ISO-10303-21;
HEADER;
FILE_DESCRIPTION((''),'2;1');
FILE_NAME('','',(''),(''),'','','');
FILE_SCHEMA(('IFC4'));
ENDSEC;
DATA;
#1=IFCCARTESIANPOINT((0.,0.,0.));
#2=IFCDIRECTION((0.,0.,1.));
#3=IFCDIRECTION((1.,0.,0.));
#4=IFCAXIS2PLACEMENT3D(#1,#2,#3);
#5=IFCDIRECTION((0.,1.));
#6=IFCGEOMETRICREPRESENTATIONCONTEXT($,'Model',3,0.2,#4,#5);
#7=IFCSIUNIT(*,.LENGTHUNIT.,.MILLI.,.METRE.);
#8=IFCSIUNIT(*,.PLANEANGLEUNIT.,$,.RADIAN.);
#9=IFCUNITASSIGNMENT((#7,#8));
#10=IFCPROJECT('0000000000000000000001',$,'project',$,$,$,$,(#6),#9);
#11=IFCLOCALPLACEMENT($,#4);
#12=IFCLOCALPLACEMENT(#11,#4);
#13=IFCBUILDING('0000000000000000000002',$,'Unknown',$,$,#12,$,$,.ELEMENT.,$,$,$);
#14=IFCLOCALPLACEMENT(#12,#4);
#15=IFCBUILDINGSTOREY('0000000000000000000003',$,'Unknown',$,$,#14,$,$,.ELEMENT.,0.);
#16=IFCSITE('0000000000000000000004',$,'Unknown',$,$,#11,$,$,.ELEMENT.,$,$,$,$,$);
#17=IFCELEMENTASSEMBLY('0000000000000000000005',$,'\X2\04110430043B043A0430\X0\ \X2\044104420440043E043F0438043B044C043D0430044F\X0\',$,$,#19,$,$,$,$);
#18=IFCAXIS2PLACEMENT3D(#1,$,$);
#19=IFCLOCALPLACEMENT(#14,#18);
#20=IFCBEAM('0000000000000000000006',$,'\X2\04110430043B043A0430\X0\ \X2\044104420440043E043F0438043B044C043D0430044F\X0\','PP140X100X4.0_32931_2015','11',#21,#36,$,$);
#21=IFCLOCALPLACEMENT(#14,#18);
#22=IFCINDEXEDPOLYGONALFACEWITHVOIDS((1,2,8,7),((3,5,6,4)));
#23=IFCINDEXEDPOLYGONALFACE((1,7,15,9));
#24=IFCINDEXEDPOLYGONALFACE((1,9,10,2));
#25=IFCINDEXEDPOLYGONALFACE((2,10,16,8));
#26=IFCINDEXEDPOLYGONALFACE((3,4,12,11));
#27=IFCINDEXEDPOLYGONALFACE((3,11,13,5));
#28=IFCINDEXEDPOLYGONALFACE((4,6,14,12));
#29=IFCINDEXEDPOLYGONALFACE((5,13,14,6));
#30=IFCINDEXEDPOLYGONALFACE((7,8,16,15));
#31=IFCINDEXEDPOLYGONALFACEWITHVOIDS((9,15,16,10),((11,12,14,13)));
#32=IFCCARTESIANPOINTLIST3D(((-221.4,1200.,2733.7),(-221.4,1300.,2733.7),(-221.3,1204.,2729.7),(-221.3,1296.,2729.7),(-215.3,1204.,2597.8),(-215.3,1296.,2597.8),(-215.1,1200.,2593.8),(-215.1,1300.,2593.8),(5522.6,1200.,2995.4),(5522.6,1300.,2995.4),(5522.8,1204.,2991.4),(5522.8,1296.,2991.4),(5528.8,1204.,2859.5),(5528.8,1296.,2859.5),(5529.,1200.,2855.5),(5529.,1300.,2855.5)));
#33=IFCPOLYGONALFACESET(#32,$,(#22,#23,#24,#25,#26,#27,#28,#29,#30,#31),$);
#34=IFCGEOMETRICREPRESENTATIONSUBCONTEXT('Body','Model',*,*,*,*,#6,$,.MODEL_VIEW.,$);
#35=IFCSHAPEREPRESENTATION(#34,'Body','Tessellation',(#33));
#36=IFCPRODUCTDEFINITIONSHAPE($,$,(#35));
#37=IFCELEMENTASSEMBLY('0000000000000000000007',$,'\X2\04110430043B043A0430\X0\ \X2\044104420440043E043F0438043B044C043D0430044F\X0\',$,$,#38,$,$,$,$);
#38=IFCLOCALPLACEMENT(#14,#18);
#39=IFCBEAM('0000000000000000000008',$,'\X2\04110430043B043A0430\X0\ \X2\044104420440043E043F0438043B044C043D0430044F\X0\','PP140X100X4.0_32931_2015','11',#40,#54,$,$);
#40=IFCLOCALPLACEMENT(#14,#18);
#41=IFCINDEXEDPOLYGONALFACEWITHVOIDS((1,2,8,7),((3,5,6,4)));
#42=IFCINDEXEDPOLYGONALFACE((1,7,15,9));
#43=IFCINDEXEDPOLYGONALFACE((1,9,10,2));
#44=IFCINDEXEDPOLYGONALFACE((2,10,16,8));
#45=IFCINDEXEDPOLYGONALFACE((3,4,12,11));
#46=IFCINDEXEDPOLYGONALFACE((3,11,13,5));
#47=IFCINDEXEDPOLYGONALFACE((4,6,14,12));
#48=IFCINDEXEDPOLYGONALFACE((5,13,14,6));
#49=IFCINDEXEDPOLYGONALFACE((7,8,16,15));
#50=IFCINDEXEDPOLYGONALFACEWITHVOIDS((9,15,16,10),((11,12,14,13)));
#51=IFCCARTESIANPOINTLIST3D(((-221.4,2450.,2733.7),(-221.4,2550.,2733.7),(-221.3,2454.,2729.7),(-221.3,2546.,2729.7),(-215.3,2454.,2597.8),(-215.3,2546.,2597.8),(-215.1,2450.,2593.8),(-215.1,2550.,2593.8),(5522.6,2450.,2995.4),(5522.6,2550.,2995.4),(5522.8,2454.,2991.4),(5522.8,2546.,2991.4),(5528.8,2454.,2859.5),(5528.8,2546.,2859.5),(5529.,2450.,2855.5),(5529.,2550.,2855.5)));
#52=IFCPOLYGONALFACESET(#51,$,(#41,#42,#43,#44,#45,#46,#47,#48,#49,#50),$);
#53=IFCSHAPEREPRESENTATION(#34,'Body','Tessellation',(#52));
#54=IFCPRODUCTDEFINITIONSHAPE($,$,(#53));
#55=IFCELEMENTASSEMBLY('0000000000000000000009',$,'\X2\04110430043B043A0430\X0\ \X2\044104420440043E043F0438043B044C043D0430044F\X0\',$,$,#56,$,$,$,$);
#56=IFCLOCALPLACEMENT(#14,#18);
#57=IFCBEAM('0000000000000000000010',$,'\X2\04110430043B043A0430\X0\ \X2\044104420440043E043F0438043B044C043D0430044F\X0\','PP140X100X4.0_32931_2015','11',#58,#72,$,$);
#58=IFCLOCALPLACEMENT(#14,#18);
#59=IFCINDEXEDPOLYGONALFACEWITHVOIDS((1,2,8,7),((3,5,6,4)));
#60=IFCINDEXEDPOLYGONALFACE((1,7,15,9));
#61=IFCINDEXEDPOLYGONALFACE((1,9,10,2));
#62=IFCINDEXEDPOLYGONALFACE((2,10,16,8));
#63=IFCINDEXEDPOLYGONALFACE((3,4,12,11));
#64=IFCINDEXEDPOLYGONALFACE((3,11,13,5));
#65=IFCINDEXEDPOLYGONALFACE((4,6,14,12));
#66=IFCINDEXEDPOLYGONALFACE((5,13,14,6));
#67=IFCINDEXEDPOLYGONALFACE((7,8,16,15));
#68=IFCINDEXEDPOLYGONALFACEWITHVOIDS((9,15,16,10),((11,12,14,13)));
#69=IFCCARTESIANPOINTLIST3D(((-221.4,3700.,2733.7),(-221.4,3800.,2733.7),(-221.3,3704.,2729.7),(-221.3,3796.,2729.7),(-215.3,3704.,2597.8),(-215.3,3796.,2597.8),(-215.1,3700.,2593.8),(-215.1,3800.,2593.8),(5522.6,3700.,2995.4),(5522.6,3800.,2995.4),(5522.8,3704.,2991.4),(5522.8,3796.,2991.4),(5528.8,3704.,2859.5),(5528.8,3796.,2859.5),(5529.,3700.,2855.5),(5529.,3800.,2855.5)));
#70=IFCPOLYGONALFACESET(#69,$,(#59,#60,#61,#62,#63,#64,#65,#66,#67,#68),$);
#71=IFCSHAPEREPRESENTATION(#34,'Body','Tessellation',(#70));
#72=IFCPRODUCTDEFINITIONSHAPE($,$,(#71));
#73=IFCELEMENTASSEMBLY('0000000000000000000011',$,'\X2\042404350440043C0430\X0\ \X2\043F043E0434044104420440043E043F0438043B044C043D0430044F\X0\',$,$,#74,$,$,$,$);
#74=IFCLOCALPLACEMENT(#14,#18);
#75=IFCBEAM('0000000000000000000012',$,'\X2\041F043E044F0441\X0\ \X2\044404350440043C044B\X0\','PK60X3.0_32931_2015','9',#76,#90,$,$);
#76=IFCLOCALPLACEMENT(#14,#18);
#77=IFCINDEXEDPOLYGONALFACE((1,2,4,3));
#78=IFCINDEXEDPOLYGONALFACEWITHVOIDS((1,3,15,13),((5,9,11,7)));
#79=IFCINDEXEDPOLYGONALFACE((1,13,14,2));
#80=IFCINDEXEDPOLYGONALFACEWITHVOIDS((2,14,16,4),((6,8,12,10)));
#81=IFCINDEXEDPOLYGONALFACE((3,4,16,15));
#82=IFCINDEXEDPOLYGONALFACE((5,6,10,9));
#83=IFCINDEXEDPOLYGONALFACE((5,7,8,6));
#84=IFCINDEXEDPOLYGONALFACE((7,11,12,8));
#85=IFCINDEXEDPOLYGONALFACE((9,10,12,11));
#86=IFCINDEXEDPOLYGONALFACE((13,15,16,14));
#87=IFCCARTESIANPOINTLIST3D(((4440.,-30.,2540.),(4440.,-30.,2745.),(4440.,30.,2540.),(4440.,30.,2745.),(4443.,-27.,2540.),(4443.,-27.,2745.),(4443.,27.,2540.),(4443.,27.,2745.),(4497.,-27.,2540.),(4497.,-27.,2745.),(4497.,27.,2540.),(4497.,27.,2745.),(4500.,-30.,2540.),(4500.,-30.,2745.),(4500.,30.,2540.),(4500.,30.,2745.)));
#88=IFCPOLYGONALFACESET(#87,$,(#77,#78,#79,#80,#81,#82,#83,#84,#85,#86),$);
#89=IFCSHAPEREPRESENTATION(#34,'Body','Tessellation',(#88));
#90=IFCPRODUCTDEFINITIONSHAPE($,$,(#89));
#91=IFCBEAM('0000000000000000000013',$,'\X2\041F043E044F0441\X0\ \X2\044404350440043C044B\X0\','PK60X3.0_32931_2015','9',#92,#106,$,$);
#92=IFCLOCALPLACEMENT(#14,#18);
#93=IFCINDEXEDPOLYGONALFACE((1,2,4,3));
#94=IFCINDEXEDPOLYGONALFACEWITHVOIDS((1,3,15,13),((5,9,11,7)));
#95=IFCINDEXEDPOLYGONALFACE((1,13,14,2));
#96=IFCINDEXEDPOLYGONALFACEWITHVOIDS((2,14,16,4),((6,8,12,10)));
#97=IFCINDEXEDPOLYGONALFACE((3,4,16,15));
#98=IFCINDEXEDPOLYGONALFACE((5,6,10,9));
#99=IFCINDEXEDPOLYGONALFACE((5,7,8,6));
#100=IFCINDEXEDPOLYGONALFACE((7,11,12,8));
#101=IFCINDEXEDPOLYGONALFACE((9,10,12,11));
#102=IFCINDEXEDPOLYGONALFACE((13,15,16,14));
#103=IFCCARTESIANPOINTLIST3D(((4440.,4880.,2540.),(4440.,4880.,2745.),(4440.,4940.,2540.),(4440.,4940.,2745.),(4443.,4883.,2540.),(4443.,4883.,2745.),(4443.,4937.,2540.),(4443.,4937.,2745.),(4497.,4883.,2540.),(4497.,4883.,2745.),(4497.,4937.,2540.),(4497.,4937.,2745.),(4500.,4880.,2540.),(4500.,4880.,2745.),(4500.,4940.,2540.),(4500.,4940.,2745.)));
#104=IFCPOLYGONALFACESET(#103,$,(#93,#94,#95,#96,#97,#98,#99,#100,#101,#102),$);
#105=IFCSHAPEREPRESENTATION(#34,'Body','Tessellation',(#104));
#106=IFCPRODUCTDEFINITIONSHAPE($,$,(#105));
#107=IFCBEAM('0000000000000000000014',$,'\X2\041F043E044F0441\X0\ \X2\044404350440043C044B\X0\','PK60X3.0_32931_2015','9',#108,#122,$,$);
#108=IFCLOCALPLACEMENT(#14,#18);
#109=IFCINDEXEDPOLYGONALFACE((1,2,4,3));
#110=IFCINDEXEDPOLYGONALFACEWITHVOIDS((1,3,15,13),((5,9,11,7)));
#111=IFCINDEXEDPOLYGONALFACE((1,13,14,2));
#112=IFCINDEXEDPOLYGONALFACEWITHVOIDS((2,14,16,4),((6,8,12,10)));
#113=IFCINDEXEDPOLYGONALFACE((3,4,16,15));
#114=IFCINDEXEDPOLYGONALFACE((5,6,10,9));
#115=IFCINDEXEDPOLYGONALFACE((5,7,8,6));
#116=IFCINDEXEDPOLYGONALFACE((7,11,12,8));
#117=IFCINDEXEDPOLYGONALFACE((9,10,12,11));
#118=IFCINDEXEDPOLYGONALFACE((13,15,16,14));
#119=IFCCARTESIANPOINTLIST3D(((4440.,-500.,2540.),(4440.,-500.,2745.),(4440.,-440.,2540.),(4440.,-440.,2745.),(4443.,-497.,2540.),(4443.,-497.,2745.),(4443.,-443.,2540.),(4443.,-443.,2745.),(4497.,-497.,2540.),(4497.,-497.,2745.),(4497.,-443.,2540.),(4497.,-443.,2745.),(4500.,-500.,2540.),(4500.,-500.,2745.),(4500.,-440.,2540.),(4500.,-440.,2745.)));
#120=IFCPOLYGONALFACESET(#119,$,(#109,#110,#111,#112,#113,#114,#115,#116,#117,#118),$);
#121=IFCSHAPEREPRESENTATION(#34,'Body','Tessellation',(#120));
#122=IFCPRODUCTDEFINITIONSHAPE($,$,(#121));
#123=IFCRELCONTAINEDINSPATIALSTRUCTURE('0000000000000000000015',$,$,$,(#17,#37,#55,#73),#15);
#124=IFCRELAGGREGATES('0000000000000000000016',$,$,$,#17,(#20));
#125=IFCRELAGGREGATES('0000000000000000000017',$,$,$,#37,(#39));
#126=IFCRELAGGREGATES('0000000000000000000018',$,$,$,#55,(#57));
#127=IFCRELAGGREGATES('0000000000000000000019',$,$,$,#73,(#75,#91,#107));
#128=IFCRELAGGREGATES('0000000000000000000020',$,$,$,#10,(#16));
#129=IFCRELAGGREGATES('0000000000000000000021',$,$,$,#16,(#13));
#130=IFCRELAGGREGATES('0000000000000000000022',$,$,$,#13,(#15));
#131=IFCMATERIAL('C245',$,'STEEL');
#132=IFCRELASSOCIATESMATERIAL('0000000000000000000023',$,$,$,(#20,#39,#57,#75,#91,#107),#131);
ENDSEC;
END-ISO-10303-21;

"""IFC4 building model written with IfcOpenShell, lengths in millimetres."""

from ifc_helpers import new_model, si_unit, direction, frame, origin_with_axes, place, context, subcontext, project, spatial, line, indexed_curve, outline, extrude, material, element, aggregate, save


model = new_model("IFC4")

# Units and contexts
model_context = context("Model", 3, precision=0.2, world=origin_with_axes(), true_north=direction((0.0, 1.0)))
body_context = subcontext(model_context, "Body", "Model", "MODEL_VIEW")
ifc_project = project(units=[si_unit("LENGTHUNIT", "METRE", prefix="MILLI"), si_unit("PLANEANGLEUNIT", "RADIAN")], contexts=[model_context])

# Site, building, storey
site_placement = place(None, origin_with_axes())
site = spatial("IfcSite", under=ifc_project, at=site_placement, Name="Unknown", CompositionType="ELEMENT")
building_placement = place(site_placement, origin_with_axes())
building = spatial("IfcBuilding", under=site, at=building_placement, Name="Unknown", CompositionType="ELEMENT")
storey_placement = place(building_placement, origin_with_axes())
storey = spatial("IfcBuildingStorey", under=building, at=storey_placement, Name="Unknown", CompositionType="ELEMENT", Elevation=0.0)

# Shared definitions
ifc_material = material(Name="C245", Category="STEEL")

# Element assemblies, beams
assembly_1_placement = place(storey_placement, frame((5525.8, 1250.0, 2925.4), z_axis=(0.0, 1.0, 0.0), x_axis=(-0.998964, 0.0, -0.045508)))
assembly_1 = element("IfcElementAssembly", 1, at=assembly_1_placement, inside=storey, Name="Балка стропильная")
beam_1_placement = place(assembly_1_placement, origin_with_axes())
beam_1 = element("IfcBeam", 2, at=beam_1_placement, material=ifc_material, Name="Балка стропильная", Description="PP140X100X4.0_32931_2015", ObjectType="11", context=body_context, shape_type="SolidModel", body=[
    extrude(outline(indexed_curve([(-50.0, -70.0), (50.0, -70.0), (50.0, 70.0), (-50.0, 70.0)], segments=[line(1, 2, 3, 4, 1)]), holes=[indexed_curve([(-46.0, -66.0), (-46.0, 66.0), (46.0, 66.0), (46.0, -66.0)], segments=[line(1, 2, 3, 4, 1)])]), frame((0.0, 0.0, 0.0), z_axis=(-1.0, 0.0, 0.0), x_axis=(0.0, 0.0, 1.0)), (0.0, 0.0, -1.0), 5750.0),
])
aggregate(assembly_1, [beam_1])
assembly_2_placement = place(storey_placement, frame((5525.8, 2500.0, 2925.4), z_axis=(0.0, 1.0, 0.0), x_axis=(-0.998964, 0.0, -0.045508)))
assembly_2 = element("IfcElementAssembly", 3, at=assembly_2_placement, inside=storey, Name="Балка стропильная")
beam_2_placement = place(assembly_2_placement, origin_with_axes())
beam_2 = element("IfcBeam", 4, at=beam_2_placement, material=ifc_material, Name="Балка стропильная", Description="PP140X100X4.0_32931_2015", ObjectType="11", context=body_context, shape_type="SolidModel", body=[
    extrude(outline(indexed_curve([(-50.0, -70.0), (50.0, -70.0), (50.0, 70.0), (-50.0, 70.0)], segments=[line(1, 2, 3, 4, 1)]), holes=[indexed_curve([(-46.0, -66.0), (-46.0, 66.0), (46.0, 66.0), (46.0, -66.0)], segments=[line(1, 2, 3, 4, 1)])]), frame((0.0, 0.0, 0.0), z_axis=(-1.0, 0.0, 0.0), x_axis=(0.0, 0.0, 1.0)), (0.0, 0.0, -1.0), 5750.0),
])
aggregate(assembly_2, [beam_2])
assembly_3_placement = place(storey_placement, frame((5525.8, 3750.0, 2925.4), z_axis=(0.0, 1.0, 0.0), x_axis=(-0.998964, 0.0, -0.045508)))
assembly_3 = element("IfcElementAssembly", 5, at=assembly_3_placement, inside=storey, Name="Балка стропильная")
beam_3_placement = place(assembly_3_placement, origin_with_axes())
beam_3 = element("IfcBeam", 6, at=beam_3_placement, material=ifc_material, Name="Балка стропильная", Description="PP140X100X4.0_32931_2015", ObjectType="11", context=body_context, shape_type="SolidModel", body=[
    extrude(outline(indexed_curve([(-50.0, -70.0), (50.0, -70.0), (50.0, 70.0), (-50.0, 70.0)], segments=[line(1, 2, 3, 4, 1)]), holes=[indexed_curve([(-46.0, -66.0), (-46.0, 66.0), (46.0, 66.0), (46.0, -66.0)], segments=[line(1, 2, 3, 4, 1)])]), frame((0.0, 0.0, 0.0), z_axis=(-1.0, 0.0, 0.0), x_axis=(0.0, 0.0, 1.0)), (0.0, 0.0, -1.0), 5750.0),
])
aggregate(assembly_3, [beam_3])

# Element assembly, beams
assembly_4_placement = place(storey_placement, frame((4470.0, 4940.0, 2775.0), z_axis=(-1.0, 0.0, 0.0), x_axis=(0.0, -1.0, 0.0)))
assembly_4 = element("IfcElementAssembly", 7, at=assembly_4_placement, inside=storey, Name="Ферма подстропильная")
beam_4_placement = place(assembly_4_placement, frame((4940.0, -30.0, 0.0), z_axis=(1.0, 0.0, 0.0), x_axis=(0.0, -1.0, 0.0)))
beam_4 = element("IfcBeam", 8, at=beam_4_placement, material=ifc_material, Name="Пояс фермы", Description="PK60X3.0_32931_2015", ObjectType="9", context=body_context, shape_type="SolidModel", body=[
    extrude(outline(indexed_curve([(-30.0, -30.0), (30.0, -30.0), (30.0, 30.0), (-30.0, 30.0)], segments=[line(1, 2, 3, 4, 1)]), holes=[indexed_curve([(-27.0, -27.0), (-27.0, 27.0), (27.0, 27.0), (27.0, -27.0)], segments=[line(1, 2, 3, 4, 1)])]), frame((0.0, 0.0, 0.0), z_axis=(-1.0, 0.0, 0.0), x_axis=(0.0, 0.0, 1.0)), (0.0, 0.0, -1.0), 205.0),
])
beam_5_placement = place(assembly_4_placement, frame((30.0, -30.0, 0.0), z_axis=(1.0, 0.0, 0.0), x_axis=(0.0, -1.0, 0.0)))
beam_5 = element("IfcBeam", 9, at=beam_5_placement, material=ifc_material, Name="Пояс фермы", Description="PK60X3.0_32931_2015", ObjectType="9", context=body_context, shape_type="SolidModel", body=[
    extrude(outline(indexed_curve([(-30.0, -30.0), (30.0, -30.0), (30.0, 30.0), (-30.0, 30.0)], segments=[line(1, 2, 3, 4, 1)]), holes=[indexed_curve([(-27.0, -27.0), (-27.0, 27.0), (27.0, 27.0), (27.0, -27.0)], segments=[line(1, 2, 3, 4, 1)])]), frame((0.0, 0.0, 0.0), z_axis=(-1.0, 0.0, 0.0), x_axis=(0.0, 0.0, 1.0)), (0.0, 0.0, -1.0), 205.0),
])
beam_6_placement = place(assembly_4_placement, frame((5410.0, -30.0, 0.0), z_axis=(1.0, 0.0, 0.0), x_axis=(0.0, -1.0, 0.0)))
beam_6 = element("IfcBeam", 10, at=beam_6_placement, material=ifc_material, Name="Пояс фермы", Description="PK60X3.0_32931_2015", ObjectType="9", context=body_context, shape_type="SolidModel", body=[
    extrude(outline(indexed_curve([(-30.0, -30.0), (30.0, -30.0), (30.0, 30.0), (-30.0, 30.0)], segments=[line(1, 2, 3, 4, 1)]), holes=[indexed_curve([(-27.0, -27.0), (-27.0, 27.0), (27.0, 27.0), (27.0, -27.0)], segments=[line(1, 2, 3, 4, 1)])]), frame((0.0, 0.0, 0.0), z_axis=(-1.0, 0.0, 0.0), x_axis=(0.0, 0.0, 1.0)), (0.0, 0.0, -1.0), 205.0),
])
aggregate(assembly_4, [beam_4, beam_5, beam_6])

save(model, "model.ifc")
